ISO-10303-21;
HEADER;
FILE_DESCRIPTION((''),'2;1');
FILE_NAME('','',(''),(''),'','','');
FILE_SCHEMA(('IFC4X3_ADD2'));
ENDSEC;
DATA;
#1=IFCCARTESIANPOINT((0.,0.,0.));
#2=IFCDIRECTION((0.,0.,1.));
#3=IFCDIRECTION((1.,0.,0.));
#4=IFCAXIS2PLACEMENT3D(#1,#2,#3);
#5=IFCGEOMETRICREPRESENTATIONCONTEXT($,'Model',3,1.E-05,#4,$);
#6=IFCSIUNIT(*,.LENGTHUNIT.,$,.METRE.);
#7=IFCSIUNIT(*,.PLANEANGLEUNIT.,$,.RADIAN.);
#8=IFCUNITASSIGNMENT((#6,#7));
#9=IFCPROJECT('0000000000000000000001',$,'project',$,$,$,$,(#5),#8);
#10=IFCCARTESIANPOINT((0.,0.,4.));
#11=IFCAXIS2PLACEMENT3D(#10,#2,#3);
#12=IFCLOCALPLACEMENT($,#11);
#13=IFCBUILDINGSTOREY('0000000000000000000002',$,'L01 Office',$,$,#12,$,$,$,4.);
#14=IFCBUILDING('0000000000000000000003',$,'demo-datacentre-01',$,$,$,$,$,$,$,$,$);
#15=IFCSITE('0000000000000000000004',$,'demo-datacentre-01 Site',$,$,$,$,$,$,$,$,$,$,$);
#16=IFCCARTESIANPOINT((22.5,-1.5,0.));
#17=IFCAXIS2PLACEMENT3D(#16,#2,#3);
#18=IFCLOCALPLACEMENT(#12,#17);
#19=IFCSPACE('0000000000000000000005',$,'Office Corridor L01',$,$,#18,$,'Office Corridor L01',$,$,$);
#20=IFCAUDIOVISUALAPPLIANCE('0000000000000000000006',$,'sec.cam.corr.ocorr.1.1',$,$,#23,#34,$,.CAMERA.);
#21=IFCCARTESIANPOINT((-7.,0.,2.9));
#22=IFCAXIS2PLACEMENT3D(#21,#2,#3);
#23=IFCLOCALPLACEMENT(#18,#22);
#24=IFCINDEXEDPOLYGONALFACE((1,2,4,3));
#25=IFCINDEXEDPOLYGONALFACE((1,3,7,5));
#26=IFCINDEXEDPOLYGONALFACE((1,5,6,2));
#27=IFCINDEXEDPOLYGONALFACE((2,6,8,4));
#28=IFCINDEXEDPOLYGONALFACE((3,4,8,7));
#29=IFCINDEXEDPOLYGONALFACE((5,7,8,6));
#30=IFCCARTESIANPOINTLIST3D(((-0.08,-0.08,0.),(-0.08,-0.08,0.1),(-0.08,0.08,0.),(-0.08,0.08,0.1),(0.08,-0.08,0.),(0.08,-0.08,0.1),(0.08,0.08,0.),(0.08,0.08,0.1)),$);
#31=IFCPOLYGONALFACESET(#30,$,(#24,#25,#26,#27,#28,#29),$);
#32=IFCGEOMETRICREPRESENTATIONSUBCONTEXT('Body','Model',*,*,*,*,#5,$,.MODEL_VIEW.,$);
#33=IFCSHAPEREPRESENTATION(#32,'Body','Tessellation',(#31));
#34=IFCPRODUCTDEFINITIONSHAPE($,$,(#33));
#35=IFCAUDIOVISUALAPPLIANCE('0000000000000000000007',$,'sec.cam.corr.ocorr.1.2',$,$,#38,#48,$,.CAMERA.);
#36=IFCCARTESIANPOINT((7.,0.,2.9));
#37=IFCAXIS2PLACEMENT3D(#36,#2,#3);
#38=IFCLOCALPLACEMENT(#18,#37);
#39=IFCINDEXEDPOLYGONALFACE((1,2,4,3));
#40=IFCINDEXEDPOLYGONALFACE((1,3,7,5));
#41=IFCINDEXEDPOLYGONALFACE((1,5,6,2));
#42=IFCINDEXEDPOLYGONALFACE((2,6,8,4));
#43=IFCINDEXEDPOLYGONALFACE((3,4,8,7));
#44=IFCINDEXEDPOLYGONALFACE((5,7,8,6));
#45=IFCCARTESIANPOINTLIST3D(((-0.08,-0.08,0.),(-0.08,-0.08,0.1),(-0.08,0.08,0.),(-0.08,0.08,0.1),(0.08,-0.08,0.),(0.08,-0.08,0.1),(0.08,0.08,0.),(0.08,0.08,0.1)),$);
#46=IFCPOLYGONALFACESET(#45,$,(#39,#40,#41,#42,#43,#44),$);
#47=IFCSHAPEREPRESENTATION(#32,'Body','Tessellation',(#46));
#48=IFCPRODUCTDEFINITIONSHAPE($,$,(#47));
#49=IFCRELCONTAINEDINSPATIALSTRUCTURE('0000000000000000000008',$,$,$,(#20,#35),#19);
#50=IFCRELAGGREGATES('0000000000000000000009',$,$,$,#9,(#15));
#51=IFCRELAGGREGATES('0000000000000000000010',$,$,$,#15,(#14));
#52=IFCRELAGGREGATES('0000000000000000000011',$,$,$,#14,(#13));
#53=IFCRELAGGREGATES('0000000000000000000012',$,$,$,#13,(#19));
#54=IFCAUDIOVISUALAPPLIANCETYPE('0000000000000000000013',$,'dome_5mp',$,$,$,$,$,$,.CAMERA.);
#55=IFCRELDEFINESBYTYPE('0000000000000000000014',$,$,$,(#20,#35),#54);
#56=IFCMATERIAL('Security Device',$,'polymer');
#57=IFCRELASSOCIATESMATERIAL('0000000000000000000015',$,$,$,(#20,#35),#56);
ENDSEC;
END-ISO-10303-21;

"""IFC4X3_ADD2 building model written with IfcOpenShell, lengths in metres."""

from ifc_helpers import new_model, si_unit, frame, origin_with_axes, place, context, subcontext, project, spatial, rectangle, extrude, source, transform, mapped, material, type_object, type_shapes, element, save


model = new_model("IFC4X3_ADD2")

# Units and contexts
model_context = context("Model", 3, precision=1e-05, world=origin_with_axes())
body_context = subcontext(model_context, "Body", "Model", "MODEL_VIEW")
ifc_project = project(units=[si_unit("LENGTHUNIT", "METRE"), si_unit("PLANEANGLEUNIT", "RADIAN")], contexts=[model_context])

# Site, building, storey, space
site = spatial("IfcSite", under=ifc_project, Name="demo-datacentre-01 Site")
building = spatial("IfcBuilding", under=site, Name="demo-datacentre-01")
storey_placement = place(None, frame((0.0, 0.0, 4.0), z_axis=(0.0, 0.0, 1.0), x_axis=(1.0, 0.0, 0.0)))
storey = spatial("IfcBuildingStorey", under=building, at=storey_placement, Name="L01 Office", Elevation=4.0)
space_placement = place(storey_placement, frame((22.5, -1.5, 0.0), z_axis=(0.0, 0.0, 1.0), x_axis=(1.0, 0.0, 0.0)))
space = spatial("IfcSpace", under=storey, at=space_placement, Name="Office Corridor L01", LongName="Office Corridor L01")

# Audio visual appliances
ifc_material = material(Name="Security Device", Category="polymer")
audio_visual_appliance_type = type_object("IfcAudioVisualApplianceType", Name="dome_5mp", PredefinedType="CAMERA")
shared_shape = source(origin_with_axes(), body_context, "Body", "SweptSolid", [
    extrude(rectangle(XDim=0.16, YDim=0.16), origin_with_axes(), (0.0, 0.0, 1.0), 0.1),
])
type_shapes(audio_visual_appliance_type, [shared_shape])
for number, where, z_axis, x_axis, name in (
    (1, (-7.0, 0.0, 2.9), (0.0, 0.0, 1.0), (1.0, 0.0, 0.0), "sec.cam.corr.ocorr.1.1"),
    (2, (7.0, 0.0, 2.9), (0.0, 0.0, 1.0), (1.0, 0.0, 0.0), "sec.cam.corr.ocorr.1.2"),
):
    element("IfcAudioVisualAppliance", number, at=place(space_placement, frame(where, z_axis=z_axis, x_axis=x_axis)), inside=space, type_object=audio_visual_appliance_type, material=ifc_material, Name=name, PredefinedType="CAMERA", context=body_context, shape_type="MappedRepresentation", body=[
        mapped(shared_shape, transform((0.0, 0.0, 0.0), x_axis=(1.0, 0.0, 0.0), y_axis=(0.0, 1.0, 0.0), z_axis=(0.0, 0.0, 1.0), scale=1.0)),
    ])

save(model, "model.ifc")
